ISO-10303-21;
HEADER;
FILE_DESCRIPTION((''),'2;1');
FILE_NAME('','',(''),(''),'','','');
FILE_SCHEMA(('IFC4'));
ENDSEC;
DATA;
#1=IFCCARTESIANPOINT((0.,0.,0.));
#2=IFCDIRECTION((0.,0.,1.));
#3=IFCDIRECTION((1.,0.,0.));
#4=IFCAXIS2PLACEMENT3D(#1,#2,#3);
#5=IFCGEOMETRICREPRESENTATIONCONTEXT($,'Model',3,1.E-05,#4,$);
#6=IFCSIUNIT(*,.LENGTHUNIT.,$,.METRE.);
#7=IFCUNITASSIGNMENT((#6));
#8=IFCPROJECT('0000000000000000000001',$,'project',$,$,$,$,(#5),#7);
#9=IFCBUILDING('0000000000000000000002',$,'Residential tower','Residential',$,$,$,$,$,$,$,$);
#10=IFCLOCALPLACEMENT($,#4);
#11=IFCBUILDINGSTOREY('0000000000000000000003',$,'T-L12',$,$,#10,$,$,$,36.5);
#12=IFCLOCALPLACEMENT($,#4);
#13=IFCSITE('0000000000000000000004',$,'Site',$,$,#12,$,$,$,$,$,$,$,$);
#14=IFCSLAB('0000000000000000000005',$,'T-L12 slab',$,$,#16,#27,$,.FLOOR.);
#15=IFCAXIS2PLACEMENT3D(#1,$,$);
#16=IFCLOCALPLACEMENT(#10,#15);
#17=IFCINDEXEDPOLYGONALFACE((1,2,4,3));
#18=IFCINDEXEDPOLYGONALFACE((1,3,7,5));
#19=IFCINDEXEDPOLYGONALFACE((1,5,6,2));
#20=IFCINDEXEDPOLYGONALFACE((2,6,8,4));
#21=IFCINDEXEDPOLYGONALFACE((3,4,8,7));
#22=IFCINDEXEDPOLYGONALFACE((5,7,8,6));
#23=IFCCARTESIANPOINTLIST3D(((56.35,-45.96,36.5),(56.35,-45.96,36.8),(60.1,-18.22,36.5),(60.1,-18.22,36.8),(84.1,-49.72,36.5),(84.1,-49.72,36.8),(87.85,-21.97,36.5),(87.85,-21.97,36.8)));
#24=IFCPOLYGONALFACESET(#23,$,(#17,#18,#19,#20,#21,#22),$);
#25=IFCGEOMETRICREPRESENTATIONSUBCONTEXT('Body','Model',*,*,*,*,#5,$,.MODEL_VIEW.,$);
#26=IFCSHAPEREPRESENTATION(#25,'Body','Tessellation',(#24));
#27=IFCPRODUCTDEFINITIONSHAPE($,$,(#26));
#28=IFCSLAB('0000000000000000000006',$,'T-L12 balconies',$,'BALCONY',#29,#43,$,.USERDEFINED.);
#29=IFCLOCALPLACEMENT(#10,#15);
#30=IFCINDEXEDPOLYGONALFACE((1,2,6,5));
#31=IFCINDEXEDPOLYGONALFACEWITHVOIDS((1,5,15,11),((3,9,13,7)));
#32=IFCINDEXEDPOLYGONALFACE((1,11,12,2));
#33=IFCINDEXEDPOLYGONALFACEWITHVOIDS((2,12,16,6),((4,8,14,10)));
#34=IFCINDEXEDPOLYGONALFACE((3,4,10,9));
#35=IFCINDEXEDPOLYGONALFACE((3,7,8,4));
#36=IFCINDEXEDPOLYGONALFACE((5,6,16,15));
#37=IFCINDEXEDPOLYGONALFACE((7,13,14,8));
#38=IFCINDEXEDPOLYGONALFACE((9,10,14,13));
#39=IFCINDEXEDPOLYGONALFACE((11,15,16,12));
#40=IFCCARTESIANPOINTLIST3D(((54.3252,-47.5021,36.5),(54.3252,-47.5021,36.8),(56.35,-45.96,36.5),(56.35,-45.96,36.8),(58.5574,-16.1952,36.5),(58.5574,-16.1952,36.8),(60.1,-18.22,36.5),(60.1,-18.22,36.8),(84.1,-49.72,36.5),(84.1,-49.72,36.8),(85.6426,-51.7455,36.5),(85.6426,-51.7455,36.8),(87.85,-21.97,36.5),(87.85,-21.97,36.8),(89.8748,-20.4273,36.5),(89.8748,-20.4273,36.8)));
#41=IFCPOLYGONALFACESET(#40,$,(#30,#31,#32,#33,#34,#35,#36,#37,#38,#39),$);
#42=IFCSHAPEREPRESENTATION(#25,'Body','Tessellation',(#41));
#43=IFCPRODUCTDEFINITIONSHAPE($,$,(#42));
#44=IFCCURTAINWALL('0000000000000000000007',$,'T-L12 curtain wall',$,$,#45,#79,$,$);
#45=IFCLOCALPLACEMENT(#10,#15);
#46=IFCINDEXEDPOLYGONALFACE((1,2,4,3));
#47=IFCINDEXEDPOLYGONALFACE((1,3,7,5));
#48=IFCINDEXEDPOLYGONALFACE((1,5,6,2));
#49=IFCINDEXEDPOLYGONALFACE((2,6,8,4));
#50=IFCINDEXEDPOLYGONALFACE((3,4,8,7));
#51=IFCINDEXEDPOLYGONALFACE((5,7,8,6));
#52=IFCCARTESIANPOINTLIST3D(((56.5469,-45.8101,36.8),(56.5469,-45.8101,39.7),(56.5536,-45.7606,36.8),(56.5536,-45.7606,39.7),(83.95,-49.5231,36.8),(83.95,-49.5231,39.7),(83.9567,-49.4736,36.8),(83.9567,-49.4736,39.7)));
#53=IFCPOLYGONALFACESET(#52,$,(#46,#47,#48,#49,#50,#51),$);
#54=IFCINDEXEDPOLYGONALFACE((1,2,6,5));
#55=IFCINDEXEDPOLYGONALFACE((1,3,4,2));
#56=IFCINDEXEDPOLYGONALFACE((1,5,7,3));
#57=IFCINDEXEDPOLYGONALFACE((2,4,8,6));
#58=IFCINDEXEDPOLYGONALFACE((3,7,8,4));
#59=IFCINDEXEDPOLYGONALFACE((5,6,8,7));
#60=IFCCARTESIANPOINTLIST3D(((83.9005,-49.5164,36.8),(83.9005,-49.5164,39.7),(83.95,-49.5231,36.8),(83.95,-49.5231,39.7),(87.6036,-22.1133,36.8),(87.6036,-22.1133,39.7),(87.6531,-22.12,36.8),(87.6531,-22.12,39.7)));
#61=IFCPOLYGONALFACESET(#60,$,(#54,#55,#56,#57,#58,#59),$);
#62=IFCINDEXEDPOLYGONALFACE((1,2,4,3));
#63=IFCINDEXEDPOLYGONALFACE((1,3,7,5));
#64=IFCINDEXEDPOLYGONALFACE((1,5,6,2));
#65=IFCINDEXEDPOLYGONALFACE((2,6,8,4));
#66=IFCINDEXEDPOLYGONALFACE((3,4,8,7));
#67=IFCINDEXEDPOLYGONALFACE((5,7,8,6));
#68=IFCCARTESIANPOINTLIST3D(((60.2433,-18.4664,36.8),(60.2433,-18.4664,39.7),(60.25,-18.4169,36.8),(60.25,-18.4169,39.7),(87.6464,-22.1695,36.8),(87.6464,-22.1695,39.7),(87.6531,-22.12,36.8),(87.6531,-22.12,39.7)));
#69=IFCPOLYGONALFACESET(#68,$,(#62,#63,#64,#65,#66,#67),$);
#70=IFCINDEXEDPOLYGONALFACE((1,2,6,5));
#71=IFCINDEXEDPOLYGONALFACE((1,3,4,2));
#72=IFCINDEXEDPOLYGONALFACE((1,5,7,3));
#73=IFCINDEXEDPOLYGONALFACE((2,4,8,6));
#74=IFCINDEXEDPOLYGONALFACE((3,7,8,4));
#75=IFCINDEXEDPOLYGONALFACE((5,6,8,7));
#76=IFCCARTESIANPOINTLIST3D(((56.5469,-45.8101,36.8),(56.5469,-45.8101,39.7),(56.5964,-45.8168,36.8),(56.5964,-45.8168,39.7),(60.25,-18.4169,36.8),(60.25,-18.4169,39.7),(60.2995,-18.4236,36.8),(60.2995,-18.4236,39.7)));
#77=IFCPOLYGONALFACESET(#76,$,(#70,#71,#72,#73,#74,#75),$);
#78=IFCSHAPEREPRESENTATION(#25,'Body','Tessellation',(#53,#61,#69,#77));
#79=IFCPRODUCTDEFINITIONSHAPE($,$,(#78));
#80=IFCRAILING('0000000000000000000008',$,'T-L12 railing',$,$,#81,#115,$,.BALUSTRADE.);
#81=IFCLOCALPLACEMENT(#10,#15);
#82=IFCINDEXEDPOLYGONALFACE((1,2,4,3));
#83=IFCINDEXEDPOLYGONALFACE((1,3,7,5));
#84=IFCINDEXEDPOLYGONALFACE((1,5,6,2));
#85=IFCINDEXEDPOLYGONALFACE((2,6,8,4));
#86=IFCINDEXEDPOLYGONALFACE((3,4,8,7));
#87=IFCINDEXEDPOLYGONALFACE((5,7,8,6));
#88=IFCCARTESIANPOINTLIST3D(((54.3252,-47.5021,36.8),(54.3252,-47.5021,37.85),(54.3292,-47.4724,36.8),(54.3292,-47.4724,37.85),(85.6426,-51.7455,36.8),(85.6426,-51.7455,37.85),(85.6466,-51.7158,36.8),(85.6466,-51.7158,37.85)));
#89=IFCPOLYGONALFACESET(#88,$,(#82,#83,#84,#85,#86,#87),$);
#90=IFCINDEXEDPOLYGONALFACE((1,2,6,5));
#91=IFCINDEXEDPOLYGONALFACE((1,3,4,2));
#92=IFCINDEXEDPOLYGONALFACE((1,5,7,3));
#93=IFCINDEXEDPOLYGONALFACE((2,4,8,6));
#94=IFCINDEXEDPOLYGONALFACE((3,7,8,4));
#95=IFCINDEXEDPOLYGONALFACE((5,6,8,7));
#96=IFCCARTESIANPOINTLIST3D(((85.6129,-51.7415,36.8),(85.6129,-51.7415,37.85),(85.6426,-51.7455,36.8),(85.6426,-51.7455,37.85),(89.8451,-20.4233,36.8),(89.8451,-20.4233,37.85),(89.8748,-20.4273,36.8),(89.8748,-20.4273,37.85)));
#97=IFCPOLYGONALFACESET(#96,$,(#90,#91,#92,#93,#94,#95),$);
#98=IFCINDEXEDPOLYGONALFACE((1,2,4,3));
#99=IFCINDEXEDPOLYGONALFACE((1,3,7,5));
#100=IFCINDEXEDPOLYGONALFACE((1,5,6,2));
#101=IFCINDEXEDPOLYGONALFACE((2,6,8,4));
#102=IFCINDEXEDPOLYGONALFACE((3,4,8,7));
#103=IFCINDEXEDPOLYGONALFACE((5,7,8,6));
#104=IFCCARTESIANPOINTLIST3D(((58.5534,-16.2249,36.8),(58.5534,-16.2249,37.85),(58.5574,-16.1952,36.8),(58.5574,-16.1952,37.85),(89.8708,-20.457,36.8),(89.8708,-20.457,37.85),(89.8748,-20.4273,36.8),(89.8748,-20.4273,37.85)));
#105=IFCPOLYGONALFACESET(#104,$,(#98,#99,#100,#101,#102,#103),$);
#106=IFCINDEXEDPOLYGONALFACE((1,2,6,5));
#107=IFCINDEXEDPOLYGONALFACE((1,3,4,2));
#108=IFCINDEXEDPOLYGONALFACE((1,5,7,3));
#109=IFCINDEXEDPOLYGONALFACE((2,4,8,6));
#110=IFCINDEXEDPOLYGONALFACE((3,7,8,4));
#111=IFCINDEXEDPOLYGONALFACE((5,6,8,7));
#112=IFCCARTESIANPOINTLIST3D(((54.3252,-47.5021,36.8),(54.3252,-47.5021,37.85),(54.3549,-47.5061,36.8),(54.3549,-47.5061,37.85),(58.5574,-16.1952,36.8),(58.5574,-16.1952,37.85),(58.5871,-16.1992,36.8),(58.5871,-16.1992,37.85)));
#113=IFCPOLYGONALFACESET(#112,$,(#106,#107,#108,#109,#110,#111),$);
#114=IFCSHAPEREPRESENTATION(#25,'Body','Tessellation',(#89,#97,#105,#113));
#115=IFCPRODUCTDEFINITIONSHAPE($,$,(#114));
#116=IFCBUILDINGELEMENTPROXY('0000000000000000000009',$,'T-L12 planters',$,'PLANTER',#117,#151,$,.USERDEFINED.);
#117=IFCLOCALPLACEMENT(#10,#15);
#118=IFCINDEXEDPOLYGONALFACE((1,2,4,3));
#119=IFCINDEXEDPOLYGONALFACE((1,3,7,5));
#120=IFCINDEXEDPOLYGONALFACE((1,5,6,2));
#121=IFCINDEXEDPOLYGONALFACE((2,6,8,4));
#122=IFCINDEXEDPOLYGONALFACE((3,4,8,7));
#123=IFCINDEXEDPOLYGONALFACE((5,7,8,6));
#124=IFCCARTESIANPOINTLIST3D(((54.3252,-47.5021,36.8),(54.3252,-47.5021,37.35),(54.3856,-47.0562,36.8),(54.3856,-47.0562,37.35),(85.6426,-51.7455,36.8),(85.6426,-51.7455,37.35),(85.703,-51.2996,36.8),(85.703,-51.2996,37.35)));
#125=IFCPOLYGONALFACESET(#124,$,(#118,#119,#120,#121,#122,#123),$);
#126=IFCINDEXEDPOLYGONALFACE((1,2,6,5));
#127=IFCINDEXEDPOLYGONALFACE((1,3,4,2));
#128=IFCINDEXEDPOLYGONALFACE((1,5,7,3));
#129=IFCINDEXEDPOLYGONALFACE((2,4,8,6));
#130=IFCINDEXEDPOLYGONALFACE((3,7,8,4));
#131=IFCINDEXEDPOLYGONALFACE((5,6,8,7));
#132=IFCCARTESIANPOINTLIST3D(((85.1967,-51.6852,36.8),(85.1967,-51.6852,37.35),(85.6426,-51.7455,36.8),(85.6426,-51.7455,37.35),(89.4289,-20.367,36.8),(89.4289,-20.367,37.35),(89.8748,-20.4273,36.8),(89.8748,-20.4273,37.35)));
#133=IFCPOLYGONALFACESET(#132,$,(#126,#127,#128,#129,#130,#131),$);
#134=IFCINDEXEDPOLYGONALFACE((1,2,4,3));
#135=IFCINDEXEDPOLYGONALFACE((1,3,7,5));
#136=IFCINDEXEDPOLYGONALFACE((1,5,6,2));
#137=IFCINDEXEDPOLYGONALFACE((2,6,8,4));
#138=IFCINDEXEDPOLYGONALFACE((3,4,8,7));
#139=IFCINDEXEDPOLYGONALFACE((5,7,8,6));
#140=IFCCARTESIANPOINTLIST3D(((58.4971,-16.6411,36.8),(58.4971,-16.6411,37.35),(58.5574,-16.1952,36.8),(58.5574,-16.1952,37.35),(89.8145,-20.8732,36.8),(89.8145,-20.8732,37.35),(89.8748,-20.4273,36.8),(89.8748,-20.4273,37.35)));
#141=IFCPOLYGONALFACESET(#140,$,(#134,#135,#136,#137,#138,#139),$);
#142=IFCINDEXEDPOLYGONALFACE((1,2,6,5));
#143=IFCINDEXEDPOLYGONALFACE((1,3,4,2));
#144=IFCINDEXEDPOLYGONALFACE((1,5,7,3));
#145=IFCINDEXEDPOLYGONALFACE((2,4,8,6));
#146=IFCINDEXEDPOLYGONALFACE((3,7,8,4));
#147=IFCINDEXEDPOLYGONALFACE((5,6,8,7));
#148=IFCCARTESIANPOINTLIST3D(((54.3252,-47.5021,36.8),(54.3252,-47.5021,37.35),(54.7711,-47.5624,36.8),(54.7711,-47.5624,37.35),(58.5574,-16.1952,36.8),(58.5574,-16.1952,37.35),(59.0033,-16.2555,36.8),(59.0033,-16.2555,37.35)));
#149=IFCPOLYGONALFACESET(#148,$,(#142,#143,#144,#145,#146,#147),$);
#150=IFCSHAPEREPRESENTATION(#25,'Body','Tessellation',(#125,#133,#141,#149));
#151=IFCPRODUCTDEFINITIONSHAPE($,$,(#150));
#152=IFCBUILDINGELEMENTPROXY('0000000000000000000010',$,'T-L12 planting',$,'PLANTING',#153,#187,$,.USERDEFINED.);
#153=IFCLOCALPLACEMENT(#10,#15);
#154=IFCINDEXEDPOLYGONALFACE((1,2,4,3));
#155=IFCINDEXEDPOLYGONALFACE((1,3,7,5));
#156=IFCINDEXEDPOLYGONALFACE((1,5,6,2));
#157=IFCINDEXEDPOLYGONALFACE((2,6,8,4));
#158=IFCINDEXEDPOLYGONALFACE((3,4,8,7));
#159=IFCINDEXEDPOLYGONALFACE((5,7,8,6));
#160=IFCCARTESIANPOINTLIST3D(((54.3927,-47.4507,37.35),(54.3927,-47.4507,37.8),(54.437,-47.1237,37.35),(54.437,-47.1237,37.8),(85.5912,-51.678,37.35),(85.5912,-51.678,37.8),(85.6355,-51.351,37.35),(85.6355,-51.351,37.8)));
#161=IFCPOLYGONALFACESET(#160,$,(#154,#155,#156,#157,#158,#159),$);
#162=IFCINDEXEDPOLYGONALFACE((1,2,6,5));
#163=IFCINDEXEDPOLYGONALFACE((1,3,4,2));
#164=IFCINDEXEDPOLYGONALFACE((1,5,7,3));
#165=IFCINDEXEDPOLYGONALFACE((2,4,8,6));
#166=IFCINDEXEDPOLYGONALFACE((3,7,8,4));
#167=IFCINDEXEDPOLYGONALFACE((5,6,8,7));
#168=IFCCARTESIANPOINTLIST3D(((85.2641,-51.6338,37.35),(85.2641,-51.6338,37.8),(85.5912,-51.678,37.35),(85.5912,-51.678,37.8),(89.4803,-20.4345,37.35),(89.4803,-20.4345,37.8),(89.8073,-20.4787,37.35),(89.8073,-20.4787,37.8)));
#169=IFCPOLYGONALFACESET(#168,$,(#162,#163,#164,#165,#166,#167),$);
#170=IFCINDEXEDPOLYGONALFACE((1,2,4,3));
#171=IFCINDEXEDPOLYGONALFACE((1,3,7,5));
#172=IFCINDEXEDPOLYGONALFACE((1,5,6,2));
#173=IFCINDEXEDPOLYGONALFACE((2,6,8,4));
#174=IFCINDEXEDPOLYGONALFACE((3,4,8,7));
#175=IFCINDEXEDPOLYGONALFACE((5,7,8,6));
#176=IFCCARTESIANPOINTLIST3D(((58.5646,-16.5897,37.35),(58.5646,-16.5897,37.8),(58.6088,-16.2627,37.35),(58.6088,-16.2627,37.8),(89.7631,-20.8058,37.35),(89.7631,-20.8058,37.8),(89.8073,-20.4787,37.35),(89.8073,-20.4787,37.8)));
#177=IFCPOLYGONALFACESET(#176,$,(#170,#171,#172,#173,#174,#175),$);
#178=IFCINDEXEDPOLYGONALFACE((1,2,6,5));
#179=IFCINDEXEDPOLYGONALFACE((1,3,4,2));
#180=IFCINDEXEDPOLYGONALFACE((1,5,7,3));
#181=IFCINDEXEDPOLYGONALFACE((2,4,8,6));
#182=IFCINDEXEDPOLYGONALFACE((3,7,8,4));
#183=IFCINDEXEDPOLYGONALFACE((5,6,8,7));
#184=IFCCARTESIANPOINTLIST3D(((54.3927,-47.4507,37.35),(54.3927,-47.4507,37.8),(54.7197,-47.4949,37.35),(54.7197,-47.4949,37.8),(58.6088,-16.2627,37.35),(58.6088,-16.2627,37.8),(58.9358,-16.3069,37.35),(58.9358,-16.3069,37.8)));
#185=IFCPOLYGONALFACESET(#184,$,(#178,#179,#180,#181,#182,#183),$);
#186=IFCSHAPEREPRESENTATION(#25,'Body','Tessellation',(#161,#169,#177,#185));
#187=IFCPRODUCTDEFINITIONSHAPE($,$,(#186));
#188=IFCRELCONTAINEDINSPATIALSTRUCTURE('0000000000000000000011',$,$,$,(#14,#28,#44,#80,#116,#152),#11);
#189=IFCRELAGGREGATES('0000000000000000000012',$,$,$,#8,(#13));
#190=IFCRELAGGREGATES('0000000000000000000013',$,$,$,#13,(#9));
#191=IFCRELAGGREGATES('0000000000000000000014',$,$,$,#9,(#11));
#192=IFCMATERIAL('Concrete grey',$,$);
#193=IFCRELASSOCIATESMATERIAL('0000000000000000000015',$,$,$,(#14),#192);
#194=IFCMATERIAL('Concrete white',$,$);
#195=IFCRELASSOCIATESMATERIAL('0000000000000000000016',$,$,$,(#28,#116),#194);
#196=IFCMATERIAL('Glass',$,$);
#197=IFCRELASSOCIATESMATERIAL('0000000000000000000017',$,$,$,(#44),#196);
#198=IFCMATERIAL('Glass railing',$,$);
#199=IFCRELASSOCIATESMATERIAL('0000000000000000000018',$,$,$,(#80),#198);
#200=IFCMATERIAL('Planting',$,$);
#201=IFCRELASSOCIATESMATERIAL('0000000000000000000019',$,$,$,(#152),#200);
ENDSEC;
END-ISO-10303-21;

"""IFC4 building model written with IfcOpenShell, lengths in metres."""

from ifc_helpers import new_model, si_unit, frame, origin_with_axes, place, context, subcontext, project, spatial, polyline, outline, extrude, material, element, save


model = new_model("IFC4")

# Units and contexts
model_context = context("Model", 3, precision=1e-05, world=origin_with_axes())
body_context = subcontext(model_context, "Body", "Model", "MODEL_VIEW")
ifc_project = project(units=[si_unit("LENGTHUNIT", "METRE")], contexts=[model_context])

# Site, building, storey
site_placement = place(None, origin_with_axes())
site = spatial("IfcSite", under=ifc_project, at=site_placement, Name="Site")
building = spatial("IfcBuilding", under=site, Name="Residential tower", Description="Residential")
storey_placement = place(None, origin_with_axes())
storey = spatial("IfcBuildingStorey", under=building, at=storey_placement, Name="T-L12", Elevation=36.5)

# Slabs
ifc_material_1 = material(Name="Concrete grey")
slab_1_placement = place(storey_placement, origin_with_axes())
element("IfcSlab", 1, at=slab_1_placement, inside=storey, material=ifc_material_1, Name="T-L12 slab", PredefinedType="FLOOR", context=body_context, shape_type="SweptSolid", body=[
    extrude(outline(polyline([(56.35, -45.96), (84.1, -49.72), (87.85, -21.97), (60.1, -18.22), (56.35, -45.96)])), frame((0.0, 0.0, 36.5), z_axis=(0.0, 0.0, 1.0), x_axis=(1.0, 0.0, 0.0)), (0.0, 0.0, 1.0), 0.3),
])
ifc_material_2 = material(Name="Concrete white")
slab_2_placement = place(storey_placement, origin_with_axes())
element("IfcSlab", 2, at=slab_2_placement, inside=storey, material=ifc_material_2, Name="T-L12 balconies", ObjectType="BALCONY", PredefinedType="USERDEFINED", context=body_context, shape_type="SweptSolid", body=[
    extrude(outline(polyline([(54.3252, -47.5021), (85.6426, -51.7455), (89.8748, -20.4273), (58.5574, -16.1952), (54.3252, -47.5021)]), holes=[polyline([(56.35, -45.96), (84.1, -49.72), (87.85, -21.97), (60.1, -18.22), (56.35, -45.96)])]), frame((0.0, 0.0, 36.5), z_axis=(0.0, 0.0, 1.0), x_axis=(1.0, 0.0, 0.0)), (0.0, 0.0, 1.0), 0.3),
])

# Curtain wall
ifc_material_3 = material(Name="Glass")
curtain_wall_placement = place(storey_placement, origin_with_axes())
element("IfcCurtainWall", 3, at=curtain_wall_placement, inside=storey, material=ifc_material_3, Name="T-L12 curtain wall", context=body_context, shape_type="SweptSolid", body=[
    extrude(outline(polyline([(56.5469, -45.8101), (83.95, -49.5231), (83.9567, -49.4736), (56.5536, -45.7606), (56.5469, -45.8101)])), frame((0.0, 0.0, 36.8), z_axis=(0.0, 0.0, 1.0), x_axis=(1.0, 0.0, 0.0)), (0.0, 0.0, 1.0), 2.9),
    extrude(outline(polyline([(83.95, -49.5231), (87.6531, -22.12), (87.6036, -22.1133), (83.9005, -49.5164), (83.95, -49.5231)])), frame((0.0, 0.0, 36.8), z_axis=(0.0, 0.0, 1.0), x_axis=(1.0, 0.0, 0.0)), (0.0, 0.0, 1.0), 2.9),
    extrude(outline(polyline([(87.6531, -22.12), (60.25, -18.4169), (60.2433, -18.4664), (87.6464, -22.1695), (87.6531, -22.12)])), frame((0.0, 0.0, 36.8), z_axis=(0.0, 0.0, 1.0), x_axis=(1.0, 0.0, 0.0)), (0.0, 0.0, 1.0), 2.9),
    extrude(outline(polyline([(60.25, -18.4169), (56.5469, -45.8101), (56.5964, -45.8168), (60.2995, -18.4236), (60.25, -18.4169)])), frame((0.0, 0.0, 36.8), z_axis=(0.0, 0.0, 1.0), x_axis=(1.0, 0.0, 0.0)), (0.0, 0.0, 1.0), 2.9),
])

# Railing
ifc_material_4 = material(Name="Glass railing")
railing_placement = place(storey_placement, origin_with_axes())
element("IfcRailing", 4, at=railing_placement, inside=storey, material=ifc_material_4, Name="T-L12 railing", PredefinedType="BALUSTRADE", context=body_context, shape_type="SweptSolid", body=[
    extrude(outline(polyline([(54.3252, -47.5021), (85.6426, -51.7455), (85.6466, -51.7158), (54.3292, -47.4724), (54.3252, -47.5021)])), frame((0.0, 0.0, 36.8), z_axis=(0.0, 0.0, 1.0), x_axis=(1.0, 0.0, 0.0)), (0.0, 0.0, 1.0), 1.05),
    extrude(outline(polyline([(85.6426, -51.7455), (89.8748, -20.4273), (89.8451, -20.4233), (85.6129, -51.7415), (85.6426, -51.7455)])), frame((0.0, 0.0, 36.8), z_axis=(0.0, 0.0, 1.0), x_axis=(1.0, 0.0, 0.0)), (0.0, 0.0, 1.0), 1.05),
    extrude(outline(polyline([(89.8748, -20.4273), (58.5574, -16.1952), (58.5534, -16.2249), (89.8708, -20.457), (89.8748, -20.4273)])), frame((0.0, 0.0, 36.8), z_axis=(0.0, 0.0, 1.0), x_axis=(1.0, 0.0, 0.0)), (0.0, 0.0, 1.0), 1.05),
    extrude(outline(polyline([(58.5574, -16.1952), (54.3252, -47.5021), (54.3549, -47.5061), (58.5871, -16.1992), (58.5574, -16.1952)])), frame((0.0, 0.0, 36.8), z_axis=(0.0, 0.0, 1.0), x_axis=(1.0, 0.0, 0.0)), (0.0, 0.0, 1.0), 1.05),
])

# Building element proxies
proxy_1_placement = place(storey_placement, origin_with_axes())
element("IfcBuildingElementProxy", 5, at=proxy_1_placement, inside=storey, material=ifc_material_2, Name="T-L12 planters", ObjectType="PLANTER", PredefinedType="USERDEFINED", context=body_context, shape_type="SweptSolid", body=[
    extrude(outline(polyline([(54.3252, -47.5021), (85.6426, -51.7455), (85.703, -51.2996), (54.3856, -47.0562), (54.3252, -47.5021)])), frame((0.0, 0.0, 36.8), z_axis=(0.0, 0.0, 1.0), x_axis=(1.0, 0.0, 0.0)), (0.0, 0.0, 1.0), 0.55),
    extrude(outline(polyline([(85.6426, -51.7455), (89.8748, -20.4273), (89.4289, -20.367), (85.1967, -51.6852), (85.6426, -51.7455)])), frame((0.0, 0.0, 36.8), z_axis=(0.0, 0.0, 1.0), x_axis=(1.0, 0.0, 0.0)), (0.0, 0.0, 1.0), 0.55),
    extrude(outline(polyline([(89.8748, -20.4273), (58.5574, -16.1952), (58.4971, -16.6411), (89.8145, -20.8732), (89.8748, -20.4273)])), frame((0.0, 0.0, 36.8), z_axis=(0.0, 0.0, 1.0), x_axis=(1.0, 0.0, 0.0)), (0.0, 0.0, 1.0), 0.55),
    extrude(outline(polyline([(58.5574, -16.1952), (54.3252, -47.5021), (54.7711, -47.5624), (59.0033, -16.2555), (58.5574, -16.1952)])), frame((0.0, 0.0, 36.8), z_axis=(0.0, 0.0, 1.0), x_axis=(1.0, 0.0, 0.0)), (0.0, 0.0, 1.0), 0.55),
])
ifc_material_5 = material(Name="Planting")
proxy_2_placement = place(storey_placement, origin_with_axes())
element("IfcBuildingElementProxy", 6, at=proxy_2_placement, inside=storey, material=ifc_material_5, Name="T-L12 planting", ObjectType="PLANTING", PredefinedType="USERDEFINED", context=body_context, shape_type="SweptSolid", body=[
    extrude(outline(polyline([(54.3927, -47.4507), (85.5912, -51.678), (85.6355, -51.351), (54.437, -47.1237), (54.3927, -47.4507)])), frame((0.0, 0.0, 37.35), z_axis=(0.0, 0.0, 1.0), x_axis=(1.0, 0.0, 0.0)), (0.0, 0.0, 1.0), 0.45),
    extrude(outline(polyline([(85.5912, -51.678), (89.8073, -20.4787), (89.4803, -20.4345), (85.2641, -51.6338), (85.5912, -51.678)])), frame((0.0, 0.0, 37.35), z_axis=(0.0, 0.0, 1.0), x_axis=(1.0, 0.0, 0.0)), (0.0, 0.0, 1.0), 0.45),
    extrude(outline(polyline([(89.8073, -20.4787), (58.6088, -16.2627), (58.5646, -16.5897), (89.7631, -20.8058), (89.8073, -20.4787)])), frame((0.0, 0.0, 37.35), z_axis=(0.0, 0.0, 1.0), x_axis=(1.0, 0.0, 0.0)), (0.0, 0.0, 1.0), 0.45),
    extrude(outline(polyline([(58.6088, -16.2627), (54.3927, -47.4507), (54.7197, -47.4949), (58.9358, -16.3069), (58.6088, -16.2627)])), frame((0.0, 0.0, 37.35), z_axis=(0.0, 0.0, 1.0), x_axis=(1.0, 0.0, 0.0)), (0.0, 0.0, 1.0), 0.45),
])

save(model, "model.ifc")
